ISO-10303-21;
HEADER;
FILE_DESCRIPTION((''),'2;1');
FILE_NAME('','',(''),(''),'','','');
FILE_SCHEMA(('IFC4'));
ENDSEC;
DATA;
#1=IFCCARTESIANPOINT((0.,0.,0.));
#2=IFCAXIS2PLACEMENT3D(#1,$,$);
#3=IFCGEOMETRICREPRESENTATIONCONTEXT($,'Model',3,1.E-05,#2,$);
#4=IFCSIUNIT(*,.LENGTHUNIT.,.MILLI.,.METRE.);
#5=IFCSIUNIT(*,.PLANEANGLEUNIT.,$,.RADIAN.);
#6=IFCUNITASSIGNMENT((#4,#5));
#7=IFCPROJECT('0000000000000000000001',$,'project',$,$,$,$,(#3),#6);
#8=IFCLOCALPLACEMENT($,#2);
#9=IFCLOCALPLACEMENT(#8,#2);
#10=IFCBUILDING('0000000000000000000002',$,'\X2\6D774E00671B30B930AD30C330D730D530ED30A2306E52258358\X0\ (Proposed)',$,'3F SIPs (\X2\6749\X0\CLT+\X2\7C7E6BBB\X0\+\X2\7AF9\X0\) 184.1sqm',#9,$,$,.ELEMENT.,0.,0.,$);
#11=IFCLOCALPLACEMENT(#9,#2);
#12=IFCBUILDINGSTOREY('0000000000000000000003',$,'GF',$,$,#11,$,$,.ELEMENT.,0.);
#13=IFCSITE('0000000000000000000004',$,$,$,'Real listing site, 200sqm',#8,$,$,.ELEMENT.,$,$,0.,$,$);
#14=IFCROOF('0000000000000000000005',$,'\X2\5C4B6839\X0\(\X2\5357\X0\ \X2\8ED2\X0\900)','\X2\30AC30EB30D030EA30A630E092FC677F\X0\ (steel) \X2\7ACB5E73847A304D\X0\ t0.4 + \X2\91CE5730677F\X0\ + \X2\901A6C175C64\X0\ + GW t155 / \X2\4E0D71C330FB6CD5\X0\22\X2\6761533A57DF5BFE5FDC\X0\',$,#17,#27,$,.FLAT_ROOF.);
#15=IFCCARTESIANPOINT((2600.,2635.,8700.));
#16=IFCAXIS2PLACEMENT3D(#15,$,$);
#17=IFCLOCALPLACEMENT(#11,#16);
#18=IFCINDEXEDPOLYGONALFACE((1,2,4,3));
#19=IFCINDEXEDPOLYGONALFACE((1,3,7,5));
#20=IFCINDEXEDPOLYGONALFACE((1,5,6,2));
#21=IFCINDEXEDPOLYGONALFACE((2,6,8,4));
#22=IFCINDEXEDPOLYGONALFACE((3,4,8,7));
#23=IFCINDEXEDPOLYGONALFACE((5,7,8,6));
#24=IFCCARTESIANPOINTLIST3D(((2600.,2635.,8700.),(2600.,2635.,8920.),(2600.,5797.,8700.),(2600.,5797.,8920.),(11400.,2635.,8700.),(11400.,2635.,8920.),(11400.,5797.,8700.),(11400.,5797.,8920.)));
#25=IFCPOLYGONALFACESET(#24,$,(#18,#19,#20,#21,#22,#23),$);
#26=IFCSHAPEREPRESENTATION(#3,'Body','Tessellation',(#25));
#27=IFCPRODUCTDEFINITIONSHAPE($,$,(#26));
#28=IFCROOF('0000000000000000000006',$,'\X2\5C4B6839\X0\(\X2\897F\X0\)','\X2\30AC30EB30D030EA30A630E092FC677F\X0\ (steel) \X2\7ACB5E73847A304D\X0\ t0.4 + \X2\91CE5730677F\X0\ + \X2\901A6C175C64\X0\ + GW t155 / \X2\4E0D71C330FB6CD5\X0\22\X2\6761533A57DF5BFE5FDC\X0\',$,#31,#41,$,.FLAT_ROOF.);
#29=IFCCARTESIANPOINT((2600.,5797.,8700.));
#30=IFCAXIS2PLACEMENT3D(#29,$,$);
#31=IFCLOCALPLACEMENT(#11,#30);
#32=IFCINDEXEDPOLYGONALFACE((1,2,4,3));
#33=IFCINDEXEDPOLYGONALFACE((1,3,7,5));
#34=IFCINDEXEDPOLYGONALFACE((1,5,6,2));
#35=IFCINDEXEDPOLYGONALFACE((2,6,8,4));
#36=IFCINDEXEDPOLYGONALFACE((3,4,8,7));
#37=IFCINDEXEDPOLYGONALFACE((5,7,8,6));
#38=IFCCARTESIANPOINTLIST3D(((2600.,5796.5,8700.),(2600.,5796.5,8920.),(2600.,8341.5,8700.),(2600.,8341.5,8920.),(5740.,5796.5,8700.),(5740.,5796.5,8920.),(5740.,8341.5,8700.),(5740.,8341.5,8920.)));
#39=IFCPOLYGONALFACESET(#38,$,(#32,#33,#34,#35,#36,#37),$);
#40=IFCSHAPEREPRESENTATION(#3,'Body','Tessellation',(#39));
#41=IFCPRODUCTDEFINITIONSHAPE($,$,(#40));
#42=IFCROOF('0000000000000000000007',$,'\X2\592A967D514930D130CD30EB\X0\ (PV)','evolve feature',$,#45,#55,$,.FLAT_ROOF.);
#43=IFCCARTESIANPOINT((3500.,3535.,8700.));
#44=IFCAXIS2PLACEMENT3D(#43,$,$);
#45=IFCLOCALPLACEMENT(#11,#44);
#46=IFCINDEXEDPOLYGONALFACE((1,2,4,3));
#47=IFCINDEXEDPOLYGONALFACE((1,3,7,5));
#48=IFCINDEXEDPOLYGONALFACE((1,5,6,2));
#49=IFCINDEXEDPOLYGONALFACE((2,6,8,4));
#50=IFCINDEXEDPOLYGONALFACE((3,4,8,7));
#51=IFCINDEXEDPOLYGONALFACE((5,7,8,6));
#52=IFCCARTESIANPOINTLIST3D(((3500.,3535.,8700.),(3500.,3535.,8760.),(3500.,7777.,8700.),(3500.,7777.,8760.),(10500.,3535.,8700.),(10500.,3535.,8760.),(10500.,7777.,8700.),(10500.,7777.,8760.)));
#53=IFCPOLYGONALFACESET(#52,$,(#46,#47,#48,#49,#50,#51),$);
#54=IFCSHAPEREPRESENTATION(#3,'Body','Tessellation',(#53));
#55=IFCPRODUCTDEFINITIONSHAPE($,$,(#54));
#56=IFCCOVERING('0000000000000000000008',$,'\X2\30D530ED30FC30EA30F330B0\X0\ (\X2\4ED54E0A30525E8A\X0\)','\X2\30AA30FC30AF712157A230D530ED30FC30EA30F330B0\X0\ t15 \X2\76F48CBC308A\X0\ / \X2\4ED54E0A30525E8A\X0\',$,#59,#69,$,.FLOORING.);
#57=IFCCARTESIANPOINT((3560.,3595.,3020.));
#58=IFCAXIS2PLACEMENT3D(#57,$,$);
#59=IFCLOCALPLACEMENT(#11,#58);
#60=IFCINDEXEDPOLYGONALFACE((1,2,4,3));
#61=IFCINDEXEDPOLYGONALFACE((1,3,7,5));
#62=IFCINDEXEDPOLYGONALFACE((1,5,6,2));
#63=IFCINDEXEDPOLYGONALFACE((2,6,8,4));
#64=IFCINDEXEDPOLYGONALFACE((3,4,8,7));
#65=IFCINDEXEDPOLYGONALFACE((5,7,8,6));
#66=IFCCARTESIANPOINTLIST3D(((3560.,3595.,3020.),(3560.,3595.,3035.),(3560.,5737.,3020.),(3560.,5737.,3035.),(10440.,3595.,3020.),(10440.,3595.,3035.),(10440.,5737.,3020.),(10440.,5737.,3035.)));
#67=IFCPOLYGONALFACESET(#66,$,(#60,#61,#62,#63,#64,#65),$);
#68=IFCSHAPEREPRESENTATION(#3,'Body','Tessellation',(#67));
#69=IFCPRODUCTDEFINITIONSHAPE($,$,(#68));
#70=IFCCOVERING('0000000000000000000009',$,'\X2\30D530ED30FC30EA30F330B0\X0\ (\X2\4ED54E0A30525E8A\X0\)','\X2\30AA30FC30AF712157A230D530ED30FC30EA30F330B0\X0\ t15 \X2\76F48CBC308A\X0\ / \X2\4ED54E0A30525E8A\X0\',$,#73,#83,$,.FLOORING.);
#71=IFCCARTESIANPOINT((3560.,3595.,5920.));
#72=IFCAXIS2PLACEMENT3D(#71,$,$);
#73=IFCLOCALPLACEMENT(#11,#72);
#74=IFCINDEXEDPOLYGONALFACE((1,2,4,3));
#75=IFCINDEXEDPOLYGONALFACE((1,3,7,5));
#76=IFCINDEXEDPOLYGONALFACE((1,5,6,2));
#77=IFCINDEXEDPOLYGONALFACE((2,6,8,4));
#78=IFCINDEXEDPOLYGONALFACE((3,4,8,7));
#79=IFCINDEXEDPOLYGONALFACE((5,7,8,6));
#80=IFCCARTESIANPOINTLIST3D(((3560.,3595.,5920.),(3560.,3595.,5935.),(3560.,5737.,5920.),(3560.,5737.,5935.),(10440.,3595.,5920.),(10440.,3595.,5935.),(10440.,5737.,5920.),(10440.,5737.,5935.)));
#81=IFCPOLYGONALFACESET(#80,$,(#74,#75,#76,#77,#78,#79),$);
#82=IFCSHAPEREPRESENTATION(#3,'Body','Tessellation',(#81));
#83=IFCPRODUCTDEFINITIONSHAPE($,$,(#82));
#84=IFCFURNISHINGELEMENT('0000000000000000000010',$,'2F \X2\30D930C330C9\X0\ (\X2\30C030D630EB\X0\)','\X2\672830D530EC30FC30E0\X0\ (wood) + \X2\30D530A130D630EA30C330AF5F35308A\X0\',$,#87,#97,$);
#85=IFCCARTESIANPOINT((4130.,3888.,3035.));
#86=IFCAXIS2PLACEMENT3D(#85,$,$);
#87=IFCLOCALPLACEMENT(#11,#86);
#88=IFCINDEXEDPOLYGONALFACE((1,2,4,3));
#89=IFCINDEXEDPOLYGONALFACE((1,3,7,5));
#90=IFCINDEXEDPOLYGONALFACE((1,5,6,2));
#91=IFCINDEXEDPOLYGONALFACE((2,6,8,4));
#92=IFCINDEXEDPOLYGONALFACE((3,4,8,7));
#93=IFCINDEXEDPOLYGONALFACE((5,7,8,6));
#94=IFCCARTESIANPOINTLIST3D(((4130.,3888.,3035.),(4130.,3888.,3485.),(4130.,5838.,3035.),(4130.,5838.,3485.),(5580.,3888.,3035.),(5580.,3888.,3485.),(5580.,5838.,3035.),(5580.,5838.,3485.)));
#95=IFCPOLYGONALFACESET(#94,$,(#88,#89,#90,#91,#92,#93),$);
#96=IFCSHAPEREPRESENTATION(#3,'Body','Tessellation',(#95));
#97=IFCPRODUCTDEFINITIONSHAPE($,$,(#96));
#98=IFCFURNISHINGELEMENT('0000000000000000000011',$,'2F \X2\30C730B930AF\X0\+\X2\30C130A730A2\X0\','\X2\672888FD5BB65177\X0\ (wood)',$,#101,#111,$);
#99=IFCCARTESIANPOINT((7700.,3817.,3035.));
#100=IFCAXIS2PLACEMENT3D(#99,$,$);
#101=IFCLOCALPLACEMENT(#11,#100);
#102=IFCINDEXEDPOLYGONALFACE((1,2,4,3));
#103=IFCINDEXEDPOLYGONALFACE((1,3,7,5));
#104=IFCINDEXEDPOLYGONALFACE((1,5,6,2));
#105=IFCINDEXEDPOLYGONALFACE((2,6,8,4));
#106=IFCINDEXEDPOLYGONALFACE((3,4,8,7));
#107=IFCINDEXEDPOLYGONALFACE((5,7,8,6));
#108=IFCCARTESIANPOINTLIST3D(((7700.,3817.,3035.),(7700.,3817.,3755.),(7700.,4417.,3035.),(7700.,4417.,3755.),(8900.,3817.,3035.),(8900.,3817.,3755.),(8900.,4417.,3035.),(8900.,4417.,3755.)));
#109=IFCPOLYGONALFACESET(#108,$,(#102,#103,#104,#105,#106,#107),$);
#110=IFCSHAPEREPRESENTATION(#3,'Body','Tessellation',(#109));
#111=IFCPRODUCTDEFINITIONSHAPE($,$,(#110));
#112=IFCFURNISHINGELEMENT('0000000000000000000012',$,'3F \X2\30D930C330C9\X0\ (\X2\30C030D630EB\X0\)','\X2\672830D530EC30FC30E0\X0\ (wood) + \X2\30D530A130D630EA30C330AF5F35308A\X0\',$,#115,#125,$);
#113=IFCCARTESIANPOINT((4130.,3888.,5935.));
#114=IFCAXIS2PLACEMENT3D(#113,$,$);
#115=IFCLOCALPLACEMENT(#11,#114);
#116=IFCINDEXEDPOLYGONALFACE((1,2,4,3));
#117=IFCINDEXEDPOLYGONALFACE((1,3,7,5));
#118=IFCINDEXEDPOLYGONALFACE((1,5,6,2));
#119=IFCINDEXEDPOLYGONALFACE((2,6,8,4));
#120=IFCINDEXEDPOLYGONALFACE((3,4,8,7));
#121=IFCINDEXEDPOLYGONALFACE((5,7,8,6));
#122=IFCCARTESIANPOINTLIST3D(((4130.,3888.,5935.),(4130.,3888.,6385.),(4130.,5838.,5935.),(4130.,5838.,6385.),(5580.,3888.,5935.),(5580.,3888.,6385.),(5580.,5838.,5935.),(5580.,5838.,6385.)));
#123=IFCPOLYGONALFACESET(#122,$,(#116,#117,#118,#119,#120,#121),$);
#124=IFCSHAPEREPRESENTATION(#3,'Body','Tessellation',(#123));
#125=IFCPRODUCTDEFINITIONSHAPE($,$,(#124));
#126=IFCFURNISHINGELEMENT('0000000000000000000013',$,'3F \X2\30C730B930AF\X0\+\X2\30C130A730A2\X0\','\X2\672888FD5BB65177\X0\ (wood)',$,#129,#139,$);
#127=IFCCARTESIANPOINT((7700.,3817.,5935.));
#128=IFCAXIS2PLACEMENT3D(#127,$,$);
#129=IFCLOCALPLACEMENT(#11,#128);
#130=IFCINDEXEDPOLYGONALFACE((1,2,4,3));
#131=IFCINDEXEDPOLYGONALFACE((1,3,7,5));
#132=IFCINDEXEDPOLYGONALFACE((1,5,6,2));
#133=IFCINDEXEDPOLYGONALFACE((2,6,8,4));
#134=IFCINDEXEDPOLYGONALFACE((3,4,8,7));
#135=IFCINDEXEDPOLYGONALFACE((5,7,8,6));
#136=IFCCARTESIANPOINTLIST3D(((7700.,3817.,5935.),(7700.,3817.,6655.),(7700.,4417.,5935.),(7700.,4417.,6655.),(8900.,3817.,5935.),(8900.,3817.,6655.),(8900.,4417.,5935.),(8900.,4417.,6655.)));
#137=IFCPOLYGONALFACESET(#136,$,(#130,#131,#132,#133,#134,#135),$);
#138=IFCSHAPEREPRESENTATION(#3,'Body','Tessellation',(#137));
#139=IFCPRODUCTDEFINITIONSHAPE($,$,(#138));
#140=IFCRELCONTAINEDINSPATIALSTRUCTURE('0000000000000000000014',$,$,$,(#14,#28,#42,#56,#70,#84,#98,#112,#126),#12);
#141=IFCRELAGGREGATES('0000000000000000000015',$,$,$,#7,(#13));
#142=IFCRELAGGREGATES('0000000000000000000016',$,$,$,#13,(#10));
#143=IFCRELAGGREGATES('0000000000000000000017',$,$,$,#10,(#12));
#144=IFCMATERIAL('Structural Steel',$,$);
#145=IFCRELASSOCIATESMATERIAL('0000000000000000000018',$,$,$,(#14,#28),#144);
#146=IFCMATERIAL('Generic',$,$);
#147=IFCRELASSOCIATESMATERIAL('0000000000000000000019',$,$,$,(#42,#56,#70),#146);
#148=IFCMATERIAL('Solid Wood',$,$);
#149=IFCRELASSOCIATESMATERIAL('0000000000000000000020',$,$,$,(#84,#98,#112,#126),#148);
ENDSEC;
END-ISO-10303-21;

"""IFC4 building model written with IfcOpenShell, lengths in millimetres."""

from ifc_helpers import new_model, si_unit, frame, frame_2d, origin, place, context, project, spatial, rectangle, extrude, material, element, save


model = new_model("IFC4")

# Units and contexts
model_context = context("Model", 3, precision=1e-05, world=origin())
ifc_project = project(units=[si_unit("LENGTHUNIT", "METRE", prefix="MILLI"), si_unit("PLANEANGLEUNIT", "RADIAN")], contexts=[model_context])

# Site, building, storey
site_placement = place(None, origin())
site = spatial("IfcSite", under=ifc_project, at=site_placement, ObjectType="Real listing site, 200sqm", CompositionType="ELEMENT", RefElevation=0.0)
building_placement = place(site_placement, origin())
building = spatial("IfcBuilding", under=site, at=building_placement, Name="海一望スキップフロアの別荘 (Proposed)", ObjectType="3F SIPs (杉CLT+籾殻+竹) 184.1sqm", CompositionType="ELEMENT", ElevationOfRefHeight=0.0, ElevationOfTerrain=0.0)
storey_placement = place(building_placement, origin())
storey = spatial("IfcBuildingStorey", under=building, at=storey_placement, Name="GF", CompositionType="ELEMENT", Elevation=0.0)

# Shared definitions
ifc_material_1 = material(Name="Solid Wood")

# Roofs
ifc_material_2 = material(Name="Structural Steel")
roof_1_placement = place(storey_placement, frame((2600.0, 2635.0, 8700.0)))
element("IfcRoof", 1, at=roof_1_placement, inside=storey, material=ifc_material_2, Name="屋根(南 軒900)", Description="ガルバリウム鋼板 (steel) 立平葺き t0.4 + 野地板 + 通気層 + GW t155 / 不燃・法22条区域対応", PredefinedType="FLAT_ROOF", context=model_context, shape_type="SweptSolid", body=[
    extrude(rectangle(XDim=8800.0, YDim=3162.0, at=frame_2d((4400.0, 1581.0))), frame((2600.0, 2635.0, 8700.0)), (0.0, 0.0, 1.0), 220.0),
])
roof_2_placement = place(storey_placement, frame((2600.0, 5797.0, 8700.0)))
element("IfcRoof", 2, at=roof_2_placement, inside=storey, material=ifc_material_2, Name="屋根(西)", Description="ガルバリウム鋼板 (steel) 立平葺き t0.4 + 野地板 + 通気層 + GW t155 / 不燃・法22条区域対応", PredefinedType="FLAT_ROOF", context=model_context, shape_type="SweptSolid", body=[
    extrude(rectangle(XDim=3140.0, YDim=2545.0, at=frame_2d((1570.0, 1272.0))), frame((2600.0, 5797.0, 8700.0)), (0.0, 0.0, 1.0), 220.0),
])
ifc_material_3 = material(Name="Generic")
roof_3_placement = place(storey_placement, frame((3500.0, 3535.0, 8700.0)))
element("IfcRoof", 3, at=roof_3_placement, inside=storey, material=ifc_material_3, Name="太陽光パネル (PV)", Description="evolve feature", PredefinedType="FLAT_ROOF", context=model_context, shape_type="SweptSolid", body=[
    extrude(rectangle(XDim=7000.0, YDim=4242.0, at=frame_2d((3500.0, 2121.0))), frame((3500.0, 3535.0, 8700.0)), (0.0, 0.0, 1.0), 60.0),
])

# Coverings
covering_1_placement = place(storey_placement, frame((3560.0, 3595.0, 3020.0)))
element("IfcCovering", 4, at=covering_1_placement, inside=storey, material=ifc_material_3, Name="フローリング (仕上げ床)", Description="オーク無垢フローリング t15 直貼り / 仕上げ床", PredefinedType="FLOORING", context=model_context, shape_type="SweptSolid", body=[
    extrude(rectangle(XDim=6880.0, YDim=2142.0, at=frame_2d((3440.0, 1071.0))), frame((3560.0, 3595.0, 3020.0)), (0.0, 0.0, 1.0), 15.0),
])
covering_2_placement = place(storey_placement, frame((3560.0, 3595.0, 5920.0)))
element("IfcCovering", 5, at=covering_2_placement, inside=storey, material=ifc_material_3, Name="フローリング (仕上げ床)", Description="オーク無垢フローリング t15 直貼り / 仕上げ床", PredefinedType="FLOORING", context=model_context, shape_type="SweptSolid", body=[
    extrude(rectangle(XDim=6880.0, YDim=2142.0, at=frame_2d((3440.0, 1071.0))), frame((3560.0, 3595.0, 5920.0)), (0.0, 0.0, 1.0), 15.0),
])

# Furnishing elements
furnishing_1_placement = place(storey_placement, frame((4130.0, 3888.0, 3035.0)))
element("IfcFurnishingElement", 6, at=furnishing_1_placement, inside=storey, material=ifc_material_1, Name="2F ベッド (ダブル)", Description="木フレーム (wood) + ファブリック張り", context=model_context, shape_type="SweptSolid", body=[
    extrude(rectangle(XDim=1450.0, YDim=1950.0, at=frame_2d((725.0, 975.0))), frame((4130.0, 3888.0, 3035.0)), (0.0, 0.0, 1.0), 450.0),
])
furnishing_2_placement = place(storey_placement, frame((7700.0, 3817.0, 3035.0)))
element("IfcFurnishingElement", 7, at=furnishing_2_placement, inside=storey, material=ifc_material_1, Name="2F デスク+チェア", Description="木製家具 (wood)", context=model_context, shape_type="SweptSolid", body=[
    extrude(rectangle(XDim=1200.0, YDim=600.0, at=frame_2d((600.0, 300.0))), frame((7700.0, 3817.0, 3035.0)), (0.0, 0.0, 1.0), 720.0),
])
furnishing_3_placement = place(storey_placement, frame((4130.0, 3888.0, 5935.0)))
element("IfcFurnishingElement", 8, at=furnishing_3_placement, inside=storey, material=ifc_material_1, Name="3F ベッド (ダブル)", Description="木フレーム (wood) + ファブリック張り", context=model_context, shape_type="SweptSolid", body=[
    extrude(rectangle(XDim=1450.0, YDim=1950.0, at=frame_2d((725.0, 975.0))), frame((4130.0, 3888.0, 5935.0)), (0.0, 0.0, 1.0), 450.0),
])
furnishing_4_placement = place(storey_placement, frame((7700.0, 3817.0, 5935.0)))
element("IfcFurnishingElement", 9, at=furnishing_4_placement, inside=storey, material=ifc_material_1, Name="3F デスク+チェア", Description="木製家具 (wood)", context=model_context, shape_type="SweptSolid", body=[
    extrude(rectangle(XDim=1200.0, YDim=600.0, at=frame_2d((600.0, 300.0))), frame((7700.0, 3817.0, 5935.0)), (0.0, 0.0, 1.0), 720.0),
])

save(model, "model.ifc")
